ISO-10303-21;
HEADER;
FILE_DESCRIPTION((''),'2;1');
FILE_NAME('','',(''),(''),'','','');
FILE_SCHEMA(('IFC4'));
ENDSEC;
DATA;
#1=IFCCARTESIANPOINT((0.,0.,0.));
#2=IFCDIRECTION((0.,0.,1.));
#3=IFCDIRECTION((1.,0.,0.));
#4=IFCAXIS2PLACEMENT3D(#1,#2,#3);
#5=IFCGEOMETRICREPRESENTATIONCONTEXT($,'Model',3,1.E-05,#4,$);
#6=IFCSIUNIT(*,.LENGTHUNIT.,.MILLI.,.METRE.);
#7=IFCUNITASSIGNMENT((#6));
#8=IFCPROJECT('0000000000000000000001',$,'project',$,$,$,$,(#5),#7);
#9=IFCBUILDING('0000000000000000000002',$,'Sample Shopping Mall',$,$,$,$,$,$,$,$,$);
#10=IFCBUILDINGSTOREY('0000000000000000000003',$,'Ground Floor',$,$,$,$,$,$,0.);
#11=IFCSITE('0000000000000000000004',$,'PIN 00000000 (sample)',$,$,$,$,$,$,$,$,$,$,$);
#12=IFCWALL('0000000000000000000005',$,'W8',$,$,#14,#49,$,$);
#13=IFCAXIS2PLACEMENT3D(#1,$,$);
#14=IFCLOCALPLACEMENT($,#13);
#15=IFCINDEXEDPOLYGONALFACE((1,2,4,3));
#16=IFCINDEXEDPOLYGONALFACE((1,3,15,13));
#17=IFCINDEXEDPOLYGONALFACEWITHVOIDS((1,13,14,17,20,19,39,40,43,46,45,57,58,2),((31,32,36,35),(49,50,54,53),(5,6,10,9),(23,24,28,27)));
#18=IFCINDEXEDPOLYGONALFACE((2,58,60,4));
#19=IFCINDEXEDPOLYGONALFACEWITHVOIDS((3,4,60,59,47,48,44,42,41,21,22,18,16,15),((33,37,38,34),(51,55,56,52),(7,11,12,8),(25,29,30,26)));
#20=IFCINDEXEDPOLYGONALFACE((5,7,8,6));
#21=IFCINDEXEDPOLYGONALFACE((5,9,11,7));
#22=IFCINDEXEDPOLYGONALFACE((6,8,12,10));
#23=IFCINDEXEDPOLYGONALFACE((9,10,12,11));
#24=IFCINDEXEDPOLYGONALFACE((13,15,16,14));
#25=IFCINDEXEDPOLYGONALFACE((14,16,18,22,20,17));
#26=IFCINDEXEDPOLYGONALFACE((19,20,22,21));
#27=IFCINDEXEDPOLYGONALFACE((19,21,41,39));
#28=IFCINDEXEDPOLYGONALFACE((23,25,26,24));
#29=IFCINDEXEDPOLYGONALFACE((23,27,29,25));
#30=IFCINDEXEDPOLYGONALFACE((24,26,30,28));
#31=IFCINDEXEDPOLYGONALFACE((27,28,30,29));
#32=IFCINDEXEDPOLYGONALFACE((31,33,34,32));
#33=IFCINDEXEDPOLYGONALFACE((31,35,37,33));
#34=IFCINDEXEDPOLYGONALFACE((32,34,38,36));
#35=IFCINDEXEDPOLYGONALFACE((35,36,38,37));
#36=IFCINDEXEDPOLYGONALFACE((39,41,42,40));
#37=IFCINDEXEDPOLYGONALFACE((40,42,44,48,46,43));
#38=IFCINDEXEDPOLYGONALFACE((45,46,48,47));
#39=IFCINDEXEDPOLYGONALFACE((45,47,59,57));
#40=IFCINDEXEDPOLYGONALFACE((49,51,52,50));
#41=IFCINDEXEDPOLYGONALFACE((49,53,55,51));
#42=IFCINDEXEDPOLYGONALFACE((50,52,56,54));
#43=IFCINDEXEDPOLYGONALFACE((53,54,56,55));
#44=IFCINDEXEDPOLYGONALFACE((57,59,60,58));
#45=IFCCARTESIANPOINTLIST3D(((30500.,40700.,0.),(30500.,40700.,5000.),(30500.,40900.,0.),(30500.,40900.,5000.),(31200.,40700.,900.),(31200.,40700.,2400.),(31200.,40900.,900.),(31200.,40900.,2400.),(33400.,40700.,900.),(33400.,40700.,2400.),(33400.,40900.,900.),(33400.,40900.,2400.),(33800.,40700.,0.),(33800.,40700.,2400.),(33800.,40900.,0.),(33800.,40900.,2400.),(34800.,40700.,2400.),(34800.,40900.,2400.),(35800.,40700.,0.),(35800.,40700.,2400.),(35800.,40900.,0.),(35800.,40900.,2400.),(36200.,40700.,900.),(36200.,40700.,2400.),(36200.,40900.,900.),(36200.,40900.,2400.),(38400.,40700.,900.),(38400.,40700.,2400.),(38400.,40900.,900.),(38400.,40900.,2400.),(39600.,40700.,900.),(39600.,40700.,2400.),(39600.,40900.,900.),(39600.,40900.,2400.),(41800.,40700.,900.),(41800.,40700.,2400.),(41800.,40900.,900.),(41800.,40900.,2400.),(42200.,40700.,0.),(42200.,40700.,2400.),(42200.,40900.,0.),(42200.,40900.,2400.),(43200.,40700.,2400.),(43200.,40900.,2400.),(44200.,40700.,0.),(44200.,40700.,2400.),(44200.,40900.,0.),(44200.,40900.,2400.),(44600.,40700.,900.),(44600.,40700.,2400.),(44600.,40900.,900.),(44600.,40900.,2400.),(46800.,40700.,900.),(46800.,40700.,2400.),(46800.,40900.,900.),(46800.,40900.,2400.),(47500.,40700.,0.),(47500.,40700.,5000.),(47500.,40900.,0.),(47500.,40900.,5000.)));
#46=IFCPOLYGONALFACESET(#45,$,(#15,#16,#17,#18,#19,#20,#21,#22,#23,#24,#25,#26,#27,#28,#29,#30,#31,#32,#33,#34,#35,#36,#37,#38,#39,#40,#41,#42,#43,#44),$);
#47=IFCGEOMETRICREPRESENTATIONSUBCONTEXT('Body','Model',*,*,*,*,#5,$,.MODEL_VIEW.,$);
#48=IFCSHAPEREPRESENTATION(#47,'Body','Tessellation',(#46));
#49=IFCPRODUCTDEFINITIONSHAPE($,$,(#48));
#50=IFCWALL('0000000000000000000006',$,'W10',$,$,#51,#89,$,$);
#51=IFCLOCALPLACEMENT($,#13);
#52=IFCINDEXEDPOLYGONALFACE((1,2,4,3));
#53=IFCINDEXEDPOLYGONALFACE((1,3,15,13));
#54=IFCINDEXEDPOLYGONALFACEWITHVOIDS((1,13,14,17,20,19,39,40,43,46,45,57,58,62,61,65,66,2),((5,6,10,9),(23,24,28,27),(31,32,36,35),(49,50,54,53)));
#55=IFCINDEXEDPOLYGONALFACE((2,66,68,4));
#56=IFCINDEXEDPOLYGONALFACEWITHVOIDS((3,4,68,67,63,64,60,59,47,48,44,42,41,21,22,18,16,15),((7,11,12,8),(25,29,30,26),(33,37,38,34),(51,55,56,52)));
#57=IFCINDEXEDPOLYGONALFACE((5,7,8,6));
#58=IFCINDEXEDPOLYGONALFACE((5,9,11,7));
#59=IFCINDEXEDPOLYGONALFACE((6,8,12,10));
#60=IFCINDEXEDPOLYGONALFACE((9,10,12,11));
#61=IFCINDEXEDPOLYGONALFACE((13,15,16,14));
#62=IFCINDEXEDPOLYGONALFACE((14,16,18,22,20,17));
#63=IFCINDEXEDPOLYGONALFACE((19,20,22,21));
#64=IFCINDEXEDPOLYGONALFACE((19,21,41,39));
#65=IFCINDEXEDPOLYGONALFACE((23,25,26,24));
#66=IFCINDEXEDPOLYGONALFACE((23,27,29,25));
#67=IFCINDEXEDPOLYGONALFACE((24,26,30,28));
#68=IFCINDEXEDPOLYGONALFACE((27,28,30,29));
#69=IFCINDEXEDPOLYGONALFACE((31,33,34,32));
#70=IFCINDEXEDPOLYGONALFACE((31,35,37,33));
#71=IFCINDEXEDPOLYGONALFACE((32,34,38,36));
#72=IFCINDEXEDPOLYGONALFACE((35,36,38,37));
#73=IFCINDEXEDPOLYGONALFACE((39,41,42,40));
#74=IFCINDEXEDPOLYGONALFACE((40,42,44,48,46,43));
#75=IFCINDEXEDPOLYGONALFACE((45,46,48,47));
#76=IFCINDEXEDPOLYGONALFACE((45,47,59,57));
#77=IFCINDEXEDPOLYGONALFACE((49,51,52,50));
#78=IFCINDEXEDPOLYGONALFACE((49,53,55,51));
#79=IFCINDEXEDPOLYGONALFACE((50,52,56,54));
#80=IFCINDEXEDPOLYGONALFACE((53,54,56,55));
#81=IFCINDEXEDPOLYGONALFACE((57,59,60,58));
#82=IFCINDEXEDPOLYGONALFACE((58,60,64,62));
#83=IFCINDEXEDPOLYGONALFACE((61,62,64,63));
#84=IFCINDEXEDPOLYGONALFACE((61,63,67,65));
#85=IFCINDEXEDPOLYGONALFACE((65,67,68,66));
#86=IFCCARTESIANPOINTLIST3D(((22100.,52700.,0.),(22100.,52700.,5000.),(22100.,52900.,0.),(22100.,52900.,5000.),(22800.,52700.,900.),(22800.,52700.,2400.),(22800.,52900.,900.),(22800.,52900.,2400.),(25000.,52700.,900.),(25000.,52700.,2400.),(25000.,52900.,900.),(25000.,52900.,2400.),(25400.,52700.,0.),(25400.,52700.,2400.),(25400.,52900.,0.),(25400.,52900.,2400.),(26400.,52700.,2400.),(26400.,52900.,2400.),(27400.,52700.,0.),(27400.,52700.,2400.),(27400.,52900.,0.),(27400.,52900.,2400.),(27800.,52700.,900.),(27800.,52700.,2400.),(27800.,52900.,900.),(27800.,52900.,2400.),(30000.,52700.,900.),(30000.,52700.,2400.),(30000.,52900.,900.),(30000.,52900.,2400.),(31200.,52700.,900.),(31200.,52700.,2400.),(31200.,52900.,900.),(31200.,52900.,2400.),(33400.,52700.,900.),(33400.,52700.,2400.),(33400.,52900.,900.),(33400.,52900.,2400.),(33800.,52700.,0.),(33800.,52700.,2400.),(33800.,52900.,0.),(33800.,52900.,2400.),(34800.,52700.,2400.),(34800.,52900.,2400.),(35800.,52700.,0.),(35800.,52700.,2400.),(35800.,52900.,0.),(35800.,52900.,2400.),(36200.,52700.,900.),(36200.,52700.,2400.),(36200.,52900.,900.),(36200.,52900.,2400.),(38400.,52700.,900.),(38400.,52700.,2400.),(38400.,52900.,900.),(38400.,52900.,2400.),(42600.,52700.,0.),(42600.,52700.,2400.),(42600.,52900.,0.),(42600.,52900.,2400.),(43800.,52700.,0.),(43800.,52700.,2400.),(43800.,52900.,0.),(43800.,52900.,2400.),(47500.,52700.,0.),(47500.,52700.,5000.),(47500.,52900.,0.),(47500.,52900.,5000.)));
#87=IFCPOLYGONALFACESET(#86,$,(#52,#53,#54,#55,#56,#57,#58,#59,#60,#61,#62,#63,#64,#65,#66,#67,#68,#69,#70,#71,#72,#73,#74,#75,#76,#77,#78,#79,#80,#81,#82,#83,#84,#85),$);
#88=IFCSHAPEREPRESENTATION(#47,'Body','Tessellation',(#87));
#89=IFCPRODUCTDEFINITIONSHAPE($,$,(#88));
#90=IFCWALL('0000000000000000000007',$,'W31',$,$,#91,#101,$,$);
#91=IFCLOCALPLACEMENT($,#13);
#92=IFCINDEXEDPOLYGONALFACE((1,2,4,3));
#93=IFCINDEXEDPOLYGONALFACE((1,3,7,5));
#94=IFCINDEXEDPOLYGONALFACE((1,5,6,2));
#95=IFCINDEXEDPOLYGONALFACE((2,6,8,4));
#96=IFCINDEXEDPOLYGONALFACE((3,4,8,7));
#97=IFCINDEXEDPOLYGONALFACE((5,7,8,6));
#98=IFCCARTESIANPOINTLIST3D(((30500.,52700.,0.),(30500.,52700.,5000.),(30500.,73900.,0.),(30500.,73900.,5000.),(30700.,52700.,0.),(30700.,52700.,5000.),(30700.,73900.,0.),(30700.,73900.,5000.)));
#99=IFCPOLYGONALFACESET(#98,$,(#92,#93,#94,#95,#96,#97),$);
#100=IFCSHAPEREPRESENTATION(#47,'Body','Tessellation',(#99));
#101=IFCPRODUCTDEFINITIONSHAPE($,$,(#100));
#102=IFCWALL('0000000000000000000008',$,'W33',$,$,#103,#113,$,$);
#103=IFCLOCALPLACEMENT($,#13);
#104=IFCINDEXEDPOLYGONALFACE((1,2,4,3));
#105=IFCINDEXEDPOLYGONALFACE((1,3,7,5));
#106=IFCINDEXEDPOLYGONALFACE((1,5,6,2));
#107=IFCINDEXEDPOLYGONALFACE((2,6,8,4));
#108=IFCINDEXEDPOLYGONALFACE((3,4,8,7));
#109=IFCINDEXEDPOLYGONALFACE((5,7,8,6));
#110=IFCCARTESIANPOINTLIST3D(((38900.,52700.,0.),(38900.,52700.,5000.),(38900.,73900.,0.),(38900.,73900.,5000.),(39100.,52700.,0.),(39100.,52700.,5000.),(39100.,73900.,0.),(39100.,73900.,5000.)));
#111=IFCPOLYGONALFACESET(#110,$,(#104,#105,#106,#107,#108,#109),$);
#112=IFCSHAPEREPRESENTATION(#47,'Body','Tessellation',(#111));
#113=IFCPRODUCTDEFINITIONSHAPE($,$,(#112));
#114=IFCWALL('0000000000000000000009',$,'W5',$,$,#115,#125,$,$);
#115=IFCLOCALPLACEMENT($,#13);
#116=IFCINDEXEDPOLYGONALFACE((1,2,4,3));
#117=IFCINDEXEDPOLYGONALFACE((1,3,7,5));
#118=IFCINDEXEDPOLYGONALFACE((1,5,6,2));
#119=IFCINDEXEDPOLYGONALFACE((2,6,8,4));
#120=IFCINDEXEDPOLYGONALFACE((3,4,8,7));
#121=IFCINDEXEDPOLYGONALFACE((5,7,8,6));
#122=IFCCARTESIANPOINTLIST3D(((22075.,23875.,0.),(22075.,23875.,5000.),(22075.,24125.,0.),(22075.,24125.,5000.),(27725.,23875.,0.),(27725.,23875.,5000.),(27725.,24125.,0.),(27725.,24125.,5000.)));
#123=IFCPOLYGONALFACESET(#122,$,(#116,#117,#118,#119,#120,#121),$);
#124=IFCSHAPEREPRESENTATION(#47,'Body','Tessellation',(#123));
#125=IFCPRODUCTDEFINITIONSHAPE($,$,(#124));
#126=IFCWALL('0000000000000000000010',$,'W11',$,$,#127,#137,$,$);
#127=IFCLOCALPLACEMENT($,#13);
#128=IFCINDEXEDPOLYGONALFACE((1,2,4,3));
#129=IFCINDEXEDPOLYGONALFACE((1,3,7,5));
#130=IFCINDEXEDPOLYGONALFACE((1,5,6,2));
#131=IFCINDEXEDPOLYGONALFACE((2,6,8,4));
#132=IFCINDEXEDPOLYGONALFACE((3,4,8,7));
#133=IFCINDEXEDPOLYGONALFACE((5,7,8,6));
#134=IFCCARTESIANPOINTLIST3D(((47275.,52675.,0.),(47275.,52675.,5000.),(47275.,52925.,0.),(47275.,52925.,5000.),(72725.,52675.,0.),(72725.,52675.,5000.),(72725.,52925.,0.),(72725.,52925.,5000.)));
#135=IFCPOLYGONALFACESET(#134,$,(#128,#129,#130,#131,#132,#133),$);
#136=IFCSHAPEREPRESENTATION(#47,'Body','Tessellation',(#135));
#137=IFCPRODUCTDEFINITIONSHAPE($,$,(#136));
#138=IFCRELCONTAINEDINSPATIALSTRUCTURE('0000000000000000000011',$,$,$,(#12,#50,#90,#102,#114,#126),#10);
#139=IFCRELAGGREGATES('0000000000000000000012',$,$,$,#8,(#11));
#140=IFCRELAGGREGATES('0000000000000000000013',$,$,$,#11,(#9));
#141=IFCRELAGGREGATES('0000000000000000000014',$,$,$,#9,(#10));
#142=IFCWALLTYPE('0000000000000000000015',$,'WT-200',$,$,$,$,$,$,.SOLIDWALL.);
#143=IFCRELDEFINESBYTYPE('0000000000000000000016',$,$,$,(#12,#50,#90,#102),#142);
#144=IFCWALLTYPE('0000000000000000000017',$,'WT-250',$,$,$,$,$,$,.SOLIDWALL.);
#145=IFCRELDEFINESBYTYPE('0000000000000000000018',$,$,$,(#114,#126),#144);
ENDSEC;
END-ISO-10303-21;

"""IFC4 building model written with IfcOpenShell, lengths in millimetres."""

from ifc_helpers import new_model, si_unit, frame, origin_with_axes, place, context, subcontext, project, spatial, indexed_curve, outline, extrude, type_object, element, save


model = new_model("IFC4")

# Units and contexts
model_context = context("Model", 3, precision=1e-05, world=origin_with_axes())
body_context = subcontext(model_context, "Body", "Model", "MODEL_VIEW")
ifc_project = project(units=[si_unit("LENGTHUNIT", "METRE", prefix="MILLI")], contexts=[model_context])

# Site, building, storey
site = spatial("IfcSite", under=ifc_project, Name="PIN 00000000 (sample)")
building = spatial("IfcBuilding", under=site, Name="Sample Shopping Mall")
storey = spatial("IfcBuildingStorey", under=building, Name="Ground Floor", Elevation=0.0)

# Walls, openings
wall_type_1 = type_object("IfcWallType", Name="WT-200", PredefinedType="SOLIDWALL")
wall_1_placement = place(None, frame((30500.0, 40700.0, 0.0), z_axis=(0.0, 0.0, 1.0), x_axis=(1.0, 0.0, 0.0)))
wall_1 = element("IfcWall", 1, at=wall_1_placement, inside=storey, type_object=wall_type_1, Name="W8", context=body_context, shape_type="SweptSolid", body=[
    extrude(outline(indexed_curve([(0.0, 0.0), (0.0, 200.0), (17000.0, 200.0), (17000.0, 0.0), (0.0, 0.0)], self_intersect=False)), origin_with_axes(), (0.0, 0.0, 1.0), 5000.0),
])
opening_1_placement = place(wall_1_placement, frame((3300.0, -100.0, 0.0), z_axis=(0.0, 0.0, 1.0), x_axis=(1.0, 0.0, 0.0)))
element("IfcOpeningElement", 2, at=opening_1_placement, cuts=wall_1, context=body_context, shape_type="SweptSolid", body=[
    extrude(outline(indexed_curve([(0.0, 0.0), (0.0, 400.0), (1000.0, 400.0), (1000.0, 0.0), (0.0, 0.0)], self_intersect=False)), origin_with_axes(), (0.0, 0.0, 1.0), 2400.0),
])
opening_2_placement = place(wall_1_placement, frame((4300.0, -100.0, 0.0), z_axis=(0.0, 0.0, 1.0), x_axis=(1.0, 0.0, 0.0)))
element("IfcOpeningElement", 3, at=opening_2_placement, cuts=wall_1, context=body_context, shape_type="SweptSolid", body=[
    extrude(outline(indexed_curve([(0.0, 0.0), (0.0, 400.0), (1000.0, 400.0), (1000.0, 0.0), (0.0, 0.0)], self_intersect=False)), origin_with_axes(), (0.0, 0.0, 1.0), 2400.0),
])
opening_3_placement = place(wall_1_placement, frame((11700.0, -100.0, 0.0), z_axis=(0.0, 0.0, 1.0), x_axis=(1.0, 0.0, 0.0)))
element("IfcOpeningElement", 4, at=opening_3_placement, cuts=wall_1, context=body_context, shape_type="SweptSolid", body=[
    extrude(outline(indexed_curve([(0.0, 0.0), (0.0, 400.0), (1000.0, 400.0), (1000.0, 0.0), (0.0, 0.0)], self_intersect=False)), origin_with_axes(), (0.0, 0.0, 1.0), 2400.0),
])
opening_4_placement = place(wall_1_placement, frame((12700.0, -100.0, 0.0), z_axis=(0.0, 0.0, 1.0), x_axis=(1.0, 0.0, 0.0)))
element("IfcOpeningElement", 5, at=opening_4_placement, cuts=wall_1, context=body_context, shape_type="SweptSolid", body=[
    extrude(outline(indexed_curve([(0.0, 0.0), (0.0, 400.0), (1000.0, 400.0), (1000.0, 0.0), (0.0, 0.0)], self_intersect=False)), origin_with_axes(), (0.0, 0.0, 1.0), 2400.0),
])
opening_5_placement = place(wall_1_placement, frame((700.0, -100.0, 900.0), z_axis=(0.0, 0.0, 1.0), x_axis=(1.0, 0.0, 0.0)))
element("IfcOpeningElement", 6, at=opening_5_placement, cuts=wall_1, context=body_context, shape_type="SweptSolid", body=[
    extrude(outline(indexed_curve([(0.0, 0.0), (0.0, 400.0), (2200.0, 400.0), (2200.0, 0.0), (0.0, 0.0)], self_intersect=False)), origin_with_axes(), (0.0, 0.0, 1.0), 1500.0),
])
opening_6_placement = place(wall_1_placement, frame((5700.0, -100.0, 900.0), z_axis=(0.0, 0.0, 1.0), x_axis=(1.0, 0.0, 0.0)))
element("IfcOpeningElement", 7, at=opening_6_placement, cuts=wall_1, context=body_context, shape_type="SweptSolid", body=[
    extrude(outline(indexed_curve([(0.0, 0.0), (0.0, 400.0), (2200.0, 400.0), (2200.0, 0.0), (0.0, 0.0)], self_intersect=False)), origin_with_axes(), (0.0, 0.0, 1.0), 1500.0),
])
opening_7_placement = place(wall_1_placement, frame((9100.0, -100.0, 900.0), z_axis=(0.0, 0.0, 1.0), x_axis=(1.0, 0.0, 0.0)))
element("IfcOpeningElement", 8, at=opening_7_placement, cuts=wall_1, context=body_context, shape_type="SweptSolid", body=[
    extrude(outline(indexed_curve([(0.0, 0.0), (0.0, 400.0), (2200.0, 400.0), (2200.0, 0.0), (0.0, 0.0)], self_intersect=False)), origin_with_axes(), (0.0, 0.0, 1.0), 1500.0),
])
opening_8_placement = place(wall_1_placement, frame((14100.0, -100.0, 900.0), z_axis=(0.0, 0.0, 1.0), x_axis=(1.0, 0.0, 0.0)))
element("IfcOpeningElement", 9, at=opening_8_placement, cuts=wall_1, context=body_context, shape_type="SweptSolid", body=[
    extrude(outline(indexed_curve([(0.0, 0.0), (0.0, 400.0), (2200.0, 400.0), (2200.0, 0.0), (0.0, 0.0)], self_intersect=False)), origin_with_axes(), (0.0, 0.0, 1.0), 1500.0),
])
wall_2_placement = place(None, frame((22100.0, 52700.0, 0.0), z_axis=(0.0, 0.0, 1.0), x_axis=(1.0, 0.0, 0.0)))
wall_2 = element("IfcWall", 10, at=wall_2_placement, inside=storey, type_object=wall_type_1, Name="W10", context=body_context, shape_type="SweptSolid", body=[
    extrude(outline(indexed_curve([(0.0, 0.0), (0.0, 200.0), (25400.0, 200.0), (25400.0, 0.0), (0.0, 0.0)], self_intersect=False)), origin_with_axes(), (0.0, 0.0, 1.0), 5000.0),
])
opening_9_placement = place(wall_2_placement, frame((3300.0, -100.0, 0.0), z_axis=(0.0, 0.0, 1.0), x_axis=(1.0, 0.0, 0.0)))
element("IfcOpeningElement", 11, at=opening_9_placement, cuts=wall_2, context=body_context, shape_type="SweptSolid", body=[
    extrude(outline(indexed_curve([(0.0, 0.0), (0.0, 400.0), (1000.0, 400.0), (1000.0, 0.0), (0.0, 0.0)], self_intersect=False)), origin_with_axes(), (0.0, 0.0, 1.0), 2400.0),
])
opening_10_placement = place(wall_2_placement, frame((4300.0, -100.0, 0.0), z_axis=(0.0, 0.0, 1.0), x_axis=(1.0, 0.0, 0.0)))
element("IfcOpeningElement", 12, at=opening_10_placement, cuts=wall_2, context=body_context, shape_type="SweptSolid", body=[
    extrude(outline(indexed_curve([(0.0, 0.0), (0.0, 400.0), (1000.0, 400.0), (1000.0, 0.0), (0.0, 0.0)], self_intersect=False)), origin_with_axes(), (0.0, 0.0, 1.0), 2400.0),
])
opening_11_placement = place(wall_2_placement, frame((11700.0, -100.0, 0.0), z_axis=(0.0, 0.0, 1.0), x_axis=(1.0, 0.0, 0.0)))
element("IfcOpeningElement", 13, at=opening_11_placement, cuts=wall_2, context=body_context, shape_type="SweptSolid", body=[
    extrude(outline(indexed_curve([(0.0, 0.0), (0.0, 400.0), (1000.0, 400.0), (1000.0, 0.0), (0.0, 0.0)], self_intersect=False)), origin_with_axes(), (0.0, 0.0, 1.0), 2400.0),
])
opening_12_placement = place(wall_2_placement, frame((12700.0, -100.0, 0.0), z_axis=(0.0, 0.0, 1.0), x_axis=(1.0, 0.0, 0.0)))
element("IfcOpeningElement", 14, at=opening_12_placement, cuts=wall_2, context=body_context, shape_type="SweptSolid", body=[
    extrude(outline(indexed_curve([(0.0, 0.0), (0.0, 400.0), (1000.0, 400.0), (1000.0, 0.0), (0.0, 0.0)], self_intersect=False)), origin_with_axes(), (0.0, 0.0, 1.0), 2400.0),
])
opening_13_placement = place(wall_2_placement, frame((20500.0, -100.0, 0.0), z_axis=(0.0, 0.0, 1.0), x_axis=(1.0, 0.0, 0.0)))
element("IfcOpeningElement", 15, at=opening_13_placement, cuts=wall_2, context=body_context, shape_type="SweptSolid", body=[
    extrude(outline(indexed_curve([(0.0, 0.0), (0.0, 400.0), (1200.0, 400.0), (1200.0, 0.0), (0.0, 0.0)], self_intersect=False)), origin_with_axes(), (0.0, 0.0, 1.0), 2400.0),
])
opening_14_placement = place(wall_2_placement, frame((700.0, -100.0, 900.0), z_axis=(0.0, 0.0, 1.0), x_axis=(1.0, 0.0, 0.0)))
element("IfcOpeningElement", 16, at=opening_14_placement, cuts=wall_2, context=body_context, shape_type="SweptSolid", body=[
    extrude(outline(indexed_curve([(0.0, 0.0), (0.0, 400.0), (2200.0, 400.0), (2200.0, 0.0), (0.0, 0.0)], self_intersect=False)), origin_with_axes(), (0.0, 0.0, 1.0), 1500.0),
])
opening_15_placement = place(wall_2_placement, frame((5700.0, -100.0, 900.0), z_axis=(0.0, 0.0, 1.0), x_axis=(1.0, 0.0, 0.0)))
element("IfcOpeningElement", 17, at=opening_15_placement, cuts=wall_2, context=body_context, shape_type="SweptSolid", body=[
    extrude(outline(indexed_curve([(0.0, 0.0), (0.0, 400.0), (2200.0, 400.0), (2200.0, 0.0), (0.0, 0.0)], self_intersect=False)), origin_with_axes(), (0.0, 0.0, 1.0), 1500.0),
])
opening_16_placement = place(wall_2_placement, frame((9100.0, -100.0, 900.0), z_axis=(0.0, 0.0, 1.0), x_axis=(1.0, 0.0, 0.0)))
element("IfcOpeningElement", 18, at=opening_16_placement, cuts=wall_2, context=body_context, shape_type="SweptSolid", body=[
    extrude(outline(indexed_curve([(0.0, 0.0), (0.0, 400.0), (2200.0, 400.0), (2200.0, 0.0), (0.0, 0.0)], self_intersect=False)), origin_with_axes(), (0.0, 0.0, 1.0), 1500.0),
])
opening_17_placement = place(wall_2_placement, frame((14100.0, -100.0, 900.0), z_axis=(0.0, 0.0, 1.0), x_axis=(1.0, 0.0, 0.0)))
element("IfcOpeningElement", 19, at=opening_17_placement, cuts=wall_2, context=body_context, shape_type="SweptSolid", body=[
    extrude(outline(indexed_curve([(0.0, 0.0), (0.0, 400.0), (2200.0, 400.0), (2200.0, 0.0), (0.0, 0.0)], self_intersect=False)), origin_with_axes(), (0.0, 0.0, 1.0), 1500.0),
])

# Walls
for number, where, z_axis, x_axis, name in (
    (20, (30700.0, 52700.0, 0.0), (0.0, 0.0, 1.0), (0.0, 1.0, 0.0), "W31"),
    (21, (39100.0, 52700.0, 0.0), (0.0, 0.0, 1.0), (0.0, 1.0, 0.0), "W33"),
):
    element("IfcWall", number, at=place(None, frame(where, z_axis=z_axis, x_axis=x_axis)), inside=storey, type_object=wall_type_1, Name=name, context=body_context, shape_type="SweptSolid", body=[
        extrude(outline(indexed_curve([(0.0, 0.0), (0.0, 200.0), (21200.0, 200.0), (21200.0, 0.0), (0.0, 0.0)], self_intersect=False)), origin_with_axes(), (0.0, 0.0, 1.0), 5000.0),
    ])
wall_type_2 = type_object("IfcWallType", Name="WT-250", PredefinedType="SOLIDWALL")
wall_3_placement = place(None, frame((22075.0, 23875.0, 0.0), z_axis=(0.0, 0.0, 1.0), x_axis=(1.0, 0.0, 0.0)))
element("IfcWall", 22, at=wall_3_placement, inside=storey, type_object=wall_type_2, Name="W5", context=body_context, shape_type="SweptSolid", body=[
    extrude(outline(indexed_curve([(0.0, 0.0), (0.0, 250.0), (5650.0, 250.0), (5650.0, 0.0), (0.0, 0.0)], self_intersect=False)), origin_with_axes(), (0.0, 0.0, 1.0), 5000.0),
])

# Wall
wall_4_placement = place(None, frame((47275.0, 52675.0, 0.0), z_axis=(0.0, 0.0, 1.0), x_axis=(1.0, 0.0, 0.0)))
element("IfcWall", 23, at=wall_4_placement, inside=storey, type_object=wall_type_2, Name="W11", context=body_context, shape_type="SweptSolid", body=[
    extrude(outline(indexed_curve([(0.0, 0.0), (0.0, 250.0), (25450.0, 250.0), (25450.0, 0.0), (0.0, 0.0)], self_intersect=False)), origin_with_axes(), (0.0, 0.0, 1.0), 5000.0),
])

save(model, "model.ifc")
